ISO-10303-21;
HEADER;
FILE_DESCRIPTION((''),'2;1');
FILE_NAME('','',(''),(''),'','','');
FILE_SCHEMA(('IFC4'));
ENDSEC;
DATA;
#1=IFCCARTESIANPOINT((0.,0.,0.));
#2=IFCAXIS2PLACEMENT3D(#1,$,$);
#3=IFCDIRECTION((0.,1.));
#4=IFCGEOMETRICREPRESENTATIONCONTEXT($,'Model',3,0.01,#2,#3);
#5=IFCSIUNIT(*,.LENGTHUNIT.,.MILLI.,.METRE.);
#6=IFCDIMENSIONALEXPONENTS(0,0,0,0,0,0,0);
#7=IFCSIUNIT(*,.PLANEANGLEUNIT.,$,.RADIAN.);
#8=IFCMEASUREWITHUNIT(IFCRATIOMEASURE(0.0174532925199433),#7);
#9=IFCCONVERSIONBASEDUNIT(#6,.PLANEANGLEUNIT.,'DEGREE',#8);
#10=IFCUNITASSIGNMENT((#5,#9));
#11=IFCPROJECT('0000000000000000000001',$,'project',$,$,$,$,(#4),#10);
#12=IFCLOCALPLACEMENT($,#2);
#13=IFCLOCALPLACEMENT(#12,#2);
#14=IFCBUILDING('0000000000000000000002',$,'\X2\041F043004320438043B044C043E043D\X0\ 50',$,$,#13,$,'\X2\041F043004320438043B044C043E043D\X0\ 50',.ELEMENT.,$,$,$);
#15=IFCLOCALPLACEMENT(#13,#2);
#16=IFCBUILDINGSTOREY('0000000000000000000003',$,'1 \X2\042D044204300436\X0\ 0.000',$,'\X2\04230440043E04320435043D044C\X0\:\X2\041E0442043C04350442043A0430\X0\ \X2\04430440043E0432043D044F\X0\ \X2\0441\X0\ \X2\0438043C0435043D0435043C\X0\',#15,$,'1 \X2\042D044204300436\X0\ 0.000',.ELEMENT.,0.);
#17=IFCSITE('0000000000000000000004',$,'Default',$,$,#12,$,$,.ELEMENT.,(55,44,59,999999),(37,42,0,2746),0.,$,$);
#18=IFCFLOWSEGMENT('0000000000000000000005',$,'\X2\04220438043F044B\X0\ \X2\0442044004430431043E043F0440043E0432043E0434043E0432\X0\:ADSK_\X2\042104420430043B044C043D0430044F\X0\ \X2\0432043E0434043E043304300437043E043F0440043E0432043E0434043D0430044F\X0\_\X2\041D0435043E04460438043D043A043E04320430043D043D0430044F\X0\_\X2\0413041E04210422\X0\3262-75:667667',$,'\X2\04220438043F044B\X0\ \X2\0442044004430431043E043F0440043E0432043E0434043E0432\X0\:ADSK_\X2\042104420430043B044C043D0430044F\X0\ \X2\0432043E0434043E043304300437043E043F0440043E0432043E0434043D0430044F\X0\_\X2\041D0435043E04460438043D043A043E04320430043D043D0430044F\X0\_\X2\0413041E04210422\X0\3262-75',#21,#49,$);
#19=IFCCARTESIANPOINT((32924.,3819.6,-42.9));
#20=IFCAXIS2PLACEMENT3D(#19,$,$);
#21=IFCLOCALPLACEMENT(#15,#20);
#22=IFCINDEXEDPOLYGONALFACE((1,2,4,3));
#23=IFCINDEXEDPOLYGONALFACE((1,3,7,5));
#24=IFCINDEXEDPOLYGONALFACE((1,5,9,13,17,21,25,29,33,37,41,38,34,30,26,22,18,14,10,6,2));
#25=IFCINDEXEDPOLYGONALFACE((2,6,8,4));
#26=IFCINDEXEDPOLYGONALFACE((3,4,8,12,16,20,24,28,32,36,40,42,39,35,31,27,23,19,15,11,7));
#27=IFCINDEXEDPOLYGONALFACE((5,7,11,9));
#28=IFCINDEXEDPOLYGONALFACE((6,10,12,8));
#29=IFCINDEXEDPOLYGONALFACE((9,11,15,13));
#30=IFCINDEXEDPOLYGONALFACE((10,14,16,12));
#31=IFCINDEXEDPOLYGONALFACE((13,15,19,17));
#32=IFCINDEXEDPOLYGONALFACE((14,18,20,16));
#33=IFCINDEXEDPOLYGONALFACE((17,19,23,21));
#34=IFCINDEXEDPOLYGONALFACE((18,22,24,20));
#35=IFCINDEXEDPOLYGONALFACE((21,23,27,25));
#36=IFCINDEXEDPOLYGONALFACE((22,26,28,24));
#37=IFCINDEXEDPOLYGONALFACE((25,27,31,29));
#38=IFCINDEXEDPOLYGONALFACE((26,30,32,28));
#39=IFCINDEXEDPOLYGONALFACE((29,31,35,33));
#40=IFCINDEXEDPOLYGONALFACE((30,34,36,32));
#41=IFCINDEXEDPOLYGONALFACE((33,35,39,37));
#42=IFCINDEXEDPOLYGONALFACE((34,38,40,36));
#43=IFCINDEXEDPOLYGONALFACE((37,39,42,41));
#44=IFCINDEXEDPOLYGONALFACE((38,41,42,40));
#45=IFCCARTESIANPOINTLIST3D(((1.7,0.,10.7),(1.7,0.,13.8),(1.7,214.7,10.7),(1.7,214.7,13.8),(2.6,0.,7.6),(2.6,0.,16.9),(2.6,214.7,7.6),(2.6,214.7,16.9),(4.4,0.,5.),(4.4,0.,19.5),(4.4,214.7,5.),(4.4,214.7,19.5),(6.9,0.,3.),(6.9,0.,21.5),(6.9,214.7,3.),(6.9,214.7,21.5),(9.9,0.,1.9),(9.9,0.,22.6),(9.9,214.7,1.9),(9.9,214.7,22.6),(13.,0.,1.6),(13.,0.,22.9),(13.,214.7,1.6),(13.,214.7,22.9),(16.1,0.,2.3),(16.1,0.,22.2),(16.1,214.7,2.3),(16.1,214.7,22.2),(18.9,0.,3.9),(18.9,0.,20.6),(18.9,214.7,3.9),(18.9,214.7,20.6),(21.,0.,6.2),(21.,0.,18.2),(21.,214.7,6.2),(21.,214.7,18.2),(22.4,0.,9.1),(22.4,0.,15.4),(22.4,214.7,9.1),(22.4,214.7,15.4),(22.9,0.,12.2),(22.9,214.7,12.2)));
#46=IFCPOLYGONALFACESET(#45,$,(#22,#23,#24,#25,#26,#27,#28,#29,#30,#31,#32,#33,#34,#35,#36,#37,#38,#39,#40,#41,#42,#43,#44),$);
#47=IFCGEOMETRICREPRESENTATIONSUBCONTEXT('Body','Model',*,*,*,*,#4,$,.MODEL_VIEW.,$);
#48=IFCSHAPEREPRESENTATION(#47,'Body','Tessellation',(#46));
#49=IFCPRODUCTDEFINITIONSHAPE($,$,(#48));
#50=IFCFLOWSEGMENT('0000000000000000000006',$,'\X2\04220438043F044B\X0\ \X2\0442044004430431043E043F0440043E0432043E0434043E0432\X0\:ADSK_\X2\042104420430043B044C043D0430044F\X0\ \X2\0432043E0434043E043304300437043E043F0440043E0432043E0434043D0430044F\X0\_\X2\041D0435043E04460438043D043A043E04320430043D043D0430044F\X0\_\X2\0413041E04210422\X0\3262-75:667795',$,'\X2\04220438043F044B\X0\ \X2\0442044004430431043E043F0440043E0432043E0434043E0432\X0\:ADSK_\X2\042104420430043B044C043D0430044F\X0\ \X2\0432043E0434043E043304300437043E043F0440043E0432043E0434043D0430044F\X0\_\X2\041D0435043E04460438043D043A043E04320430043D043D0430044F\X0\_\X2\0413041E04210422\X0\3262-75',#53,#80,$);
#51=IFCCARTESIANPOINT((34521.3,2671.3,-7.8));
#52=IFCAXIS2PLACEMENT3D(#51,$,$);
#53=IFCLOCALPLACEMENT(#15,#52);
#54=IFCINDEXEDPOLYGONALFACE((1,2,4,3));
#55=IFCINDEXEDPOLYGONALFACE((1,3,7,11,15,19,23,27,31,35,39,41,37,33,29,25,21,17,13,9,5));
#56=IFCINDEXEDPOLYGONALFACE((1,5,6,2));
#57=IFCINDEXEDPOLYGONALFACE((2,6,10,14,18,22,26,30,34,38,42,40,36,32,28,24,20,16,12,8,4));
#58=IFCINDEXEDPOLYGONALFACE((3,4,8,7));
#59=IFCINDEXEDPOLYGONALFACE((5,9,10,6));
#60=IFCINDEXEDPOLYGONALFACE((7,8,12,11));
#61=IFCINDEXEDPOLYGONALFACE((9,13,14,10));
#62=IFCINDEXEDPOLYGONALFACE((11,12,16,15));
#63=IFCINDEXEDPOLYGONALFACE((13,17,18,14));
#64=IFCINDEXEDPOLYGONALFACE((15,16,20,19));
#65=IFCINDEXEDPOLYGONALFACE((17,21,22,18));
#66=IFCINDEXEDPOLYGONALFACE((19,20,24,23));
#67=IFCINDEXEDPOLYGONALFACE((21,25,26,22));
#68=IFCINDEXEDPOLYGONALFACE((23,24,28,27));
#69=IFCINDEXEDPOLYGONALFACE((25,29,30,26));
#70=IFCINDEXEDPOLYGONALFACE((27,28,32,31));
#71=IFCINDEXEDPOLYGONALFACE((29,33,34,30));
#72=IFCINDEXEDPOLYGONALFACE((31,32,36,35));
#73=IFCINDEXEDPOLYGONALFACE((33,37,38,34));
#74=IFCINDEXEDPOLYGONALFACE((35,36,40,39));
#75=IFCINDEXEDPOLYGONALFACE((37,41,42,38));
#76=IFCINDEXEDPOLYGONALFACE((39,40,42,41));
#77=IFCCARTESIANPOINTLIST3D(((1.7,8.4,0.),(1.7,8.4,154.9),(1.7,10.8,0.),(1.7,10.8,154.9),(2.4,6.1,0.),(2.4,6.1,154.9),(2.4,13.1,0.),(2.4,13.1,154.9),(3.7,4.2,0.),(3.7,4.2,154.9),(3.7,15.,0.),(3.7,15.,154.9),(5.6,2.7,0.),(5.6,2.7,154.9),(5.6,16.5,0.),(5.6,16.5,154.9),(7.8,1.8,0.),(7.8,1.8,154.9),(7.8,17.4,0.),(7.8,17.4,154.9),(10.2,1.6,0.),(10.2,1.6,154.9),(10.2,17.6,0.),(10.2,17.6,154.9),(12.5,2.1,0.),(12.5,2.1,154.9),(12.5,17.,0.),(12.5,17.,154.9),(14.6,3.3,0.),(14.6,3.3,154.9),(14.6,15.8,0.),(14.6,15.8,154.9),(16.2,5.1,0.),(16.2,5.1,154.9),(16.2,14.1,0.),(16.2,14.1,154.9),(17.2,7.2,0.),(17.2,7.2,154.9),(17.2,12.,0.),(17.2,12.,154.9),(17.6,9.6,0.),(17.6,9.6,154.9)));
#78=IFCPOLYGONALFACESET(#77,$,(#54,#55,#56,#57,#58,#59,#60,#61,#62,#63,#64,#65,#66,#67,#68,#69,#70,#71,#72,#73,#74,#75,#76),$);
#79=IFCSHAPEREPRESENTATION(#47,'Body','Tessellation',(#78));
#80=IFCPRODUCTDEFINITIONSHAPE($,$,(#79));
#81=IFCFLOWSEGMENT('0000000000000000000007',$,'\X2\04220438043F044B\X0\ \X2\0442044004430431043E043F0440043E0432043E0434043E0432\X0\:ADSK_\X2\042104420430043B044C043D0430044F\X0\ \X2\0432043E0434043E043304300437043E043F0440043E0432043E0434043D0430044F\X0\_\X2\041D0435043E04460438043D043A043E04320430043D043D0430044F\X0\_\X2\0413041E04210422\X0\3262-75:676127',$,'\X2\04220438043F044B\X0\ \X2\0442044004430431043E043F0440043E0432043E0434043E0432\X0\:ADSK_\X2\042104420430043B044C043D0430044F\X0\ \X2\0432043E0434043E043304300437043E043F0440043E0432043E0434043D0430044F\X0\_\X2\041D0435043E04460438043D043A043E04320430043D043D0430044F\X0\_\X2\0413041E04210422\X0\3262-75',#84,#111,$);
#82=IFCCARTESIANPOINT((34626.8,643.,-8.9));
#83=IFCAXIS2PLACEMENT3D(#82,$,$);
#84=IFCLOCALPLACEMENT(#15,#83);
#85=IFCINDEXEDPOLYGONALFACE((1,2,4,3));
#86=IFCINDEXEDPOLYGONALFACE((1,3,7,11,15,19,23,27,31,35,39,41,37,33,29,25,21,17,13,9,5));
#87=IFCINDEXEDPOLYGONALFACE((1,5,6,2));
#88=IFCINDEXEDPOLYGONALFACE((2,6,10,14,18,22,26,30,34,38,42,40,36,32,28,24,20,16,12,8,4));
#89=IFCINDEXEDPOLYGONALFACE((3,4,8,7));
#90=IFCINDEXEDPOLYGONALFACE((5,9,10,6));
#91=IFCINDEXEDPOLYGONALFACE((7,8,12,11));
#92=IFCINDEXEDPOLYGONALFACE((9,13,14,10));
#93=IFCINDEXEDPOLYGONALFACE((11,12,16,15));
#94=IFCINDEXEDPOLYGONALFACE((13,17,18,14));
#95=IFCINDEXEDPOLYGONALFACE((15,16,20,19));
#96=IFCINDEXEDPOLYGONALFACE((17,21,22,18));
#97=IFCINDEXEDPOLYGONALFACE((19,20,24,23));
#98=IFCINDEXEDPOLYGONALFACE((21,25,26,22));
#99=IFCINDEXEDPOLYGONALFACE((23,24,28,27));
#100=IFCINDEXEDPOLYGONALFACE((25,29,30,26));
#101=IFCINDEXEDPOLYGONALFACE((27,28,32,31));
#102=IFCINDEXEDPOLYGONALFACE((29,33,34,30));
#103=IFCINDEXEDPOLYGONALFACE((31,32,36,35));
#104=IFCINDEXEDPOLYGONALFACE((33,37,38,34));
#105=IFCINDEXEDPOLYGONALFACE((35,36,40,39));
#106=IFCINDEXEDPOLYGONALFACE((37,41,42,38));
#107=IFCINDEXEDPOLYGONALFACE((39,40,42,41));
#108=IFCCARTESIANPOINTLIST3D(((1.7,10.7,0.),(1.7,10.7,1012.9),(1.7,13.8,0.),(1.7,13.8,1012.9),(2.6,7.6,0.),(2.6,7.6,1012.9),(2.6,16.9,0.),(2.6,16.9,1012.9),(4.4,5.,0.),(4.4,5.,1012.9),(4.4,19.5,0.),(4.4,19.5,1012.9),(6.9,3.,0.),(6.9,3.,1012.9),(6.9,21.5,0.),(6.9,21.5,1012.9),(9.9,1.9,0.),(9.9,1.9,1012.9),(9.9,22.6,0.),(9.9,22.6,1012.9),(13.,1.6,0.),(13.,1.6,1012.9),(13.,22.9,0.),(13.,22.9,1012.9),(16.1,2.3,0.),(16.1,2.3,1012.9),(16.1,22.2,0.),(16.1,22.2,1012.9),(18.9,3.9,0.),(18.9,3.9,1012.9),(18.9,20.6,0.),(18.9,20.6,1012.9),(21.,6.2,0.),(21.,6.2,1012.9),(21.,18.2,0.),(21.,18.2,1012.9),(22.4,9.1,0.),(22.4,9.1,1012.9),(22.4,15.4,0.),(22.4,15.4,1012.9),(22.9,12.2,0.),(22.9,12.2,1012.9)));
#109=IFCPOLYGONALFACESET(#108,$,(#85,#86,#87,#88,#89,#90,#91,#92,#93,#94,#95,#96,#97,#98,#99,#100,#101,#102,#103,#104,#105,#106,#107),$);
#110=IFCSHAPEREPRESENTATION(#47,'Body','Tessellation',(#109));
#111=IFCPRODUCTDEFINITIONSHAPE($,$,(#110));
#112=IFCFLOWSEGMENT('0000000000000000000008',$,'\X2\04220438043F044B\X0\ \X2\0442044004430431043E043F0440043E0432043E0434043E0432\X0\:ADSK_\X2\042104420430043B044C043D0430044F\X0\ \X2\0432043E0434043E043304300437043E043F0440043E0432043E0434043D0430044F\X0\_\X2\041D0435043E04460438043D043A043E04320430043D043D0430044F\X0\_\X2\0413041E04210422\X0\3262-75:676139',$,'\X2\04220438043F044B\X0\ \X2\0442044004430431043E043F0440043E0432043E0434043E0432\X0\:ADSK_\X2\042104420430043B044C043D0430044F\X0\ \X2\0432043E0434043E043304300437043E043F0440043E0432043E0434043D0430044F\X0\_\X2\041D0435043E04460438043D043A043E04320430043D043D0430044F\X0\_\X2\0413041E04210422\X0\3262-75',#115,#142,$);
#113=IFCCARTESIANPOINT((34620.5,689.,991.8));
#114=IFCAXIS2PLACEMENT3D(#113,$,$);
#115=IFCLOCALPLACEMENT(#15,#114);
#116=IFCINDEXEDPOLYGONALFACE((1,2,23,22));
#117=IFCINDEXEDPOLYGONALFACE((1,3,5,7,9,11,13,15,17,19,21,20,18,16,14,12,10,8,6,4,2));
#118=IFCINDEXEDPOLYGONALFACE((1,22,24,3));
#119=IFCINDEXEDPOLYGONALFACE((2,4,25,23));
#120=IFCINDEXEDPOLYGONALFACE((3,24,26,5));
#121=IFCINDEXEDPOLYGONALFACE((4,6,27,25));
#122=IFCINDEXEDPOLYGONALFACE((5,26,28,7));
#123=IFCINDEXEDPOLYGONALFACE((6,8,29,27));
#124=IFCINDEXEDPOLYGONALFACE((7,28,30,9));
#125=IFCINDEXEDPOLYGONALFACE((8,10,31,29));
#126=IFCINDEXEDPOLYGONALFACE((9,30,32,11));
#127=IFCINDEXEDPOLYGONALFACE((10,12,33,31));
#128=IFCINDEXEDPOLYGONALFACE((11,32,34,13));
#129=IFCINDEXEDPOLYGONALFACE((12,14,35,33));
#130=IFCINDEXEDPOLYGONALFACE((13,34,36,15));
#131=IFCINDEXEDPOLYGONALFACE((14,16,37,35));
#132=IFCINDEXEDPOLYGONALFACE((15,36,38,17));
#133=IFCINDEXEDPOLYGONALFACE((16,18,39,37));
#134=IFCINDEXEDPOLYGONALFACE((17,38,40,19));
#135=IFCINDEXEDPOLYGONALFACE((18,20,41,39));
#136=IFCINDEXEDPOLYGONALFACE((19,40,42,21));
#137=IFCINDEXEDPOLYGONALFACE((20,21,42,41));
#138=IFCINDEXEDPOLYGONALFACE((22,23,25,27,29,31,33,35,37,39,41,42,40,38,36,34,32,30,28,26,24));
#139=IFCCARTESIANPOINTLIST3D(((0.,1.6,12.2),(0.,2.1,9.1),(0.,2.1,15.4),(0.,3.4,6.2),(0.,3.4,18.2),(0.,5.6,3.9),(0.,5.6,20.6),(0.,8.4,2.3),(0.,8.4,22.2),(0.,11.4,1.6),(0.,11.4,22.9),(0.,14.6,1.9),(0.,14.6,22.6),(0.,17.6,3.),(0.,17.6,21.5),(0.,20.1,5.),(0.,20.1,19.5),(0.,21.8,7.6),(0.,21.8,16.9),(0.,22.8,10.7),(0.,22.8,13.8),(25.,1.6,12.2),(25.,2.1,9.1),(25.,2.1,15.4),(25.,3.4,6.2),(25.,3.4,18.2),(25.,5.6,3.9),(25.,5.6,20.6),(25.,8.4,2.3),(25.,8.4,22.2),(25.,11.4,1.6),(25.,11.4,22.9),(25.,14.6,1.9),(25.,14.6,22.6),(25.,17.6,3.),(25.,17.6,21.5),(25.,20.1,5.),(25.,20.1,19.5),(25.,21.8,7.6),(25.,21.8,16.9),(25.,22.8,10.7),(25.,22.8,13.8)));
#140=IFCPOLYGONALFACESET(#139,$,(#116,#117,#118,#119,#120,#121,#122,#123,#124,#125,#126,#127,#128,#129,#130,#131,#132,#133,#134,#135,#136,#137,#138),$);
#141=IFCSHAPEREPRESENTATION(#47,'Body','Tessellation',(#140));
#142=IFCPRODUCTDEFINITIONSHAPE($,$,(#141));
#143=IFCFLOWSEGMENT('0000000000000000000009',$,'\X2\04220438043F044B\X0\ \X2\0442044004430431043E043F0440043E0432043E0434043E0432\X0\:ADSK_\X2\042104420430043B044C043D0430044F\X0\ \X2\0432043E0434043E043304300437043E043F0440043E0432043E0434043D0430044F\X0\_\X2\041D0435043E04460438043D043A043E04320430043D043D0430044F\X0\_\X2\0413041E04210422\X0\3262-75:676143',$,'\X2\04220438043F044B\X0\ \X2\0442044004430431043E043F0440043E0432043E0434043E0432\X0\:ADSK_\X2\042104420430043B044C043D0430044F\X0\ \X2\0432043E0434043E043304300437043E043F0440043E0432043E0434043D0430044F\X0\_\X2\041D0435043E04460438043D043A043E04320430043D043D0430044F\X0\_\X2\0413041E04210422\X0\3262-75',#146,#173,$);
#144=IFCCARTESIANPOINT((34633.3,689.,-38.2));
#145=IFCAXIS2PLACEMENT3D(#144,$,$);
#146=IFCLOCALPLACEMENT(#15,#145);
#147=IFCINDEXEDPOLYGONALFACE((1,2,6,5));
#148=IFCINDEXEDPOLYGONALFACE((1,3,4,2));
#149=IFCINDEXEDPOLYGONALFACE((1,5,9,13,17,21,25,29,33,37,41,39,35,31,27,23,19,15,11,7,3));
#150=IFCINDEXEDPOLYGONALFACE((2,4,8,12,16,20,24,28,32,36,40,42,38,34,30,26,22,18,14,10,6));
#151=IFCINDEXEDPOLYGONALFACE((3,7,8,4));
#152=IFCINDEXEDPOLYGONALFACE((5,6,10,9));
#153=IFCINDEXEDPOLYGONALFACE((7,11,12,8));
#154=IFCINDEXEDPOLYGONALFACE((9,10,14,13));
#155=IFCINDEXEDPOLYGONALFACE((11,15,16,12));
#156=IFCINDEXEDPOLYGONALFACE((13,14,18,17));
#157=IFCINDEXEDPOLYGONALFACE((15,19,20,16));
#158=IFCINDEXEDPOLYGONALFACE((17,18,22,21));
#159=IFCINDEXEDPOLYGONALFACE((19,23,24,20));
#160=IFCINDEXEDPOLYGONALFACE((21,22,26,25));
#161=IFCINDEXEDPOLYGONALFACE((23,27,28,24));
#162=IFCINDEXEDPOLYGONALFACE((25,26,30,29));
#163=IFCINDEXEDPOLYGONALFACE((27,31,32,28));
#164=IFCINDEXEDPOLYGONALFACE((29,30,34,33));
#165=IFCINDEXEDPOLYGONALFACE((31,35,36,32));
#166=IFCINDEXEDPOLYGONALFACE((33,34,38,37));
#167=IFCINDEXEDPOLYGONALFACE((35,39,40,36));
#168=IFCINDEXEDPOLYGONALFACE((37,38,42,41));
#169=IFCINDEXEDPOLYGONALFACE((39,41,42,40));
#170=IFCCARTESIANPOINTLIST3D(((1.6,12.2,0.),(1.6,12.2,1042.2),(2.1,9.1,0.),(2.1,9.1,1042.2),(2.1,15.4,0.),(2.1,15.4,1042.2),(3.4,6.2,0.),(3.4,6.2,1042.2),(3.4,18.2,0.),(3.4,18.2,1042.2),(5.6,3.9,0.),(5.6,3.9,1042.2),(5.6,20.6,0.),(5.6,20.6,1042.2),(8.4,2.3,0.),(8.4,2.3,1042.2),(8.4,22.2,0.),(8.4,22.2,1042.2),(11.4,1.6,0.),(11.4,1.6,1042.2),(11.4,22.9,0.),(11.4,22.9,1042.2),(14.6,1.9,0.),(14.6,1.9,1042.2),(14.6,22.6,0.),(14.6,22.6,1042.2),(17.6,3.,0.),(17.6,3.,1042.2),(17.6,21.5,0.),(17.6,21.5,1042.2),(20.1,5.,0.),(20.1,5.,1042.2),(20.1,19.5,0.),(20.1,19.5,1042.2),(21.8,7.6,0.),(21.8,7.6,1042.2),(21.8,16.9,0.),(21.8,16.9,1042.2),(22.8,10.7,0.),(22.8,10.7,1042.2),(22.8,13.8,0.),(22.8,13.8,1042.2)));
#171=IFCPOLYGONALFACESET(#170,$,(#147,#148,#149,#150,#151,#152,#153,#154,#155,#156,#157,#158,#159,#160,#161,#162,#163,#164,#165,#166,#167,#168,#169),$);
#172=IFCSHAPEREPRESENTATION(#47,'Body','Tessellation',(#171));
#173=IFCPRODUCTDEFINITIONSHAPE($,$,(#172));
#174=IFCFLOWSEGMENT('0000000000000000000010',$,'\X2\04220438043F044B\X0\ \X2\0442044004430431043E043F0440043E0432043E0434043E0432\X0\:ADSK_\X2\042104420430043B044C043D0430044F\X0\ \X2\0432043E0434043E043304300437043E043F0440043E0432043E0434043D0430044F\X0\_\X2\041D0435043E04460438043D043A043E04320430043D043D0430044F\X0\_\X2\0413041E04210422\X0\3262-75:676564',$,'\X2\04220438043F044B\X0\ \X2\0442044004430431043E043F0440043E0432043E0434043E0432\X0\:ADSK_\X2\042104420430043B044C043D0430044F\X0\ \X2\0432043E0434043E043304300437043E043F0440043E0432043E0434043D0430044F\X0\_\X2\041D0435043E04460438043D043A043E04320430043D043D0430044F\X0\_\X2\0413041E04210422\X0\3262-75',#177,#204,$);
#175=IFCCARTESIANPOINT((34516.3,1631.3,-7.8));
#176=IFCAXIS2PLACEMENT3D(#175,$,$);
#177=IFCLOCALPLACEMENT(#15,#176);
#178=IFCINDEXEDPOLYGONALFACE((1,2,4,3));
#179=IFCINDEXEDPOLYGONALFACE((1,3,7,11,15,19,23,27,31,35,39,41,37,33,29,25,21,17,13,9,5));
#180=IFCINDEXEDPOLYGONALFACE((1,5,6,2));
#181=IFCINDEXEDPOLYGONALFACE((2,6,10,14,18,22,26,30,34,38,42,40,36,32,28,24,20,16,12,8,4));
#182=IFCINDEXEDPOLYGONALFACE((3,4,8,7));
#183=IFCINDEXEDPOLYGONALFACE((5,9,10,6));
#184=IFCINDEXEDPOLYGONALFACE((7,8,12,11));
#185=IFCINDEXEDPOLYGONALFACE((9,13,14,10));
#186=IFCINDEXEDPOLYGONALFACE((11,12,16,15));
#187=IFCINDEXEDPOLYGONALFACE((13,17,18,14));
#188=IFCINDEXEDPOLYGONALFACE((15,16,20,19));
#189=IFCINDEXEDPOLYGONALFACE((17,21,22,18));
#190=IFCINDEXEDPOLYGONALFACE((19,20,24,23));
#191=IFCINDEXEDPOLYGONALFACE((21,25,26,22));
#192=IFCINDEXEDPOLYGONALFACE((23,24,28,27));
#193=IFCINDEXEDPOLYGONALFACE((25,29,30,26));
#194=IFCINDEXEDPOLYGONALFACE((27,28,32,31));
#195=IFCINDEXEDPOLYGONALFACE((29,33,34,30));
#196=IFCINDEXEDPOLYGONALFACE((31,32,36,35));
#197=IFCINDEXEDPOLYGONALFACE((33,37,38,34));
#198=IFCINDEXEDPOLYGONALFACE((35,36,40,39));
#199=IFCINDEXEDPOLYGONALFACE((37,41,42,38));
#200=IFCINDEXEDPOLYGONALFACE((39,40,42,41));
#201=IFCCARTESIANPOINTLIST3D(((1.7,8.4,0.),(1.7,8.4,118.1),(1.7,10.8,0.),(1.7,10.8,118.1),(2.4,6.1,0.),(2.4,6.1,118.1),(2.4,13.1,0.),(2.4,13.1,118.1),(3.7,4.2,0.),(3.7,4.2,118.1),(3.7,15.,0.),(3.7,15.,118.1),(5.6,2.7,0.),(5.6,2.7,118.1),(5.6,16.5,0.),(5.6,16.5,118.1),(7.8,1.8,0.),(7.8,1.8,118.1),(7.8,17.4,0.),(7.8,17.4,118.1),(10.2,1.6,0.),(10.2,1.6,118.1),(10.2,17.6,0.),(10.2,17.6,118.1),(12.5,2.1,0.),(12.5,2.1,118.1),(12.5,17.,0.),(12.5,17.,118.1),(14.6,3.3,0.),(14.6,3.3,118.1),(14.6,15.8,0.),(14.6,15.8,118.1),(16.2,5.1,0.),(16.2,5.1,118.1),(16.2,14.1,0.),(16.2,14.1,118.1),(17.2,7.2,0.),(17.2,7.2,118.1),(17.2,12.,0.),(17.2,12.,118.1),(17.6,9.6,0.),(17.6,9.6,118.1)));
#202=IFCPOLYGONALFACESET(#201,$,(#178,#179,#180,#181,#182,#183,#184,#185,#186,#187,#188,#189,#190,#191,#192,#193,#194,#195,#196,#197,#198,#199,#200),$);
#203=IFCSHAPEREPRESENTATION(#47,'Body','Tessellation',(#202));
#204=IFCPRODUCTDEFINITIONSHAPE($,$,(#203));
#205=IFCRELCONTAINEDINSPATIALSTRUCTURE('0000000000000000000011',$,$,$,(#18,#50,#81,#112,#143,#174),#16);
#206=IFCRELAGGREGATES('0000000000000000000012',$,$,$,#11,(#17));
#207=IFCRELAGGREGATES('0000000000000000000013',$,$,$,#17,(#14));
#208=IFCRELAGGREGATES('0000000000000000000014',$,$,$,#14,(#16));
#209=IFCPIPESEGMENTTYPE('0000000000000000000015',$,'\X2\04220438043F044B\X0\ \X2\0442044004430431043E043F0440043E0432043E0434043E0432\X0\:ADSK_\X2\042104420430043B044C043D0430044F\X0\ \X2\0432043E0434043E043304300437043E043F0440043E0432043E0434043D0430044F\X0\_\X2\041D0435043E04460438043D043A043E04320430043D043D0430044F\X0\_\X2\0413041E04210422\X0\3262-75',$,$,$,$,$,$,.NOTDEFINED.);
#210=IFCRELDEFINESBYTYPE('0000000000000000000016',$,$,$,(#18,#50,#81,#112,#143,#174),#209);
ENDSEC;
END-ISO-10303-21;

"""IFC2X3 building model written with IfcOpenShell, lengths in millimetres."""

from ifc_helpers import new_model, entity, si_unit, converted_unit, direction, frame, frame_2d, origin, origin_2d_with_axis, place, context, subcontext, project, spatial, circle, extrude, type_object, element, save


model = new_model("IFC2X3")

# Units and contexts
model_context = context("Model", 3, precision=0.01, world=origin(), true_north=direction((0.0, 1.0)))
body_context = subcontext(model_context, "Body", "Model", "MODEL_VIEW")
ifc_project = project(units=[si_unit("LENGTHUNIT", "METRE", prefix="MILLI"), converted_unit("PLANEANGLEUNIT", "DEGREE", entity("IfcRatioMeasure", 0.0174532925199433), si_unit("PLANEANGLEUNIT", "RADIAN"), dimensions=[0, 0, 0, 0, 0, 0, 0])], contexts=[model_context])

# Site, building, storey
site_placement = place(None, origin())
site = spatial("IfcSite", under=ifc_project, at=site_placement, Name="Default", CompositionType="ELEMENT", RefLatitude=(55, 44, 59, 999999), RefLongitude=(37, 42, 0, 2746), RefElevation=0.0)
building_placement = place(site_placement, origin())
building = spatial("IfcBuilding", under=site, at=building_placement, Name="Павильон 50", LongName="Павильон 50", CompositionType="ELEMENT")
storey_placement = place(building_placement, origin())
storey = spatial("IfcBuildingStorey", under=building, at=storey_placement, Name="1 Этаж 0.000", ObjectType="Уровень:Отметка уровня с именем", LongName="1 Этаж 0.000", CompositionType="ELEMENT", Elevation=0.0)

# Flow segments
pipe_segment_type = type_object("IfcPipeSegmentType", Name="Типы трубопроводов:ADSK_Стальная водогазопроводная_Неоцинкованная_ГОСТ3262-75", PredefinedType="NOTDEFINED")
flow_segment_1_placement = place(storey_placement, frame((32924.0, 3819.6, -42.9)))
element("IfcFlowSegment", 1, at=flow_segment_1_placement, inside=storey, type_object=pipe_segment_type, Name="Типы трубопроводов:ADSK_Стальная водогазопроводная_Неоцинкованная_ГОСТ3262-75:667667", ObjectType="Типы трубопроводов:ADSK_Стальная водогазопроводная_Неоцинкованная_ГОСТ3262-75", context=body_context, shape_type="SweptSolid", body=[
    extrude(circle(Radius=10.7, at=frame_2d((0.0, 0.0), x_axis=(1.0, 0.0))), frame((12.2, 0.0, 12.2), z_axis=(0.0, 1.0, 0.0), x_axis=(1.0, 0.0, 0.0)), (0.0, 0.0, 1.0), 214.7),
])
flow_segment_2_placement = place(storey_placement, frame((34521.3, 2671.3, -7.8)))
element("IfcFlowSegment", 2, at=flow_segment_2_placement, inside=storey, type_object=pipe_segment_type, Name="Типы трубопроводов:ADSK_Стальная водогазопроводная_Неоцинкованная_ГОСТ3262-75:667795", ObjectType="Типы трубопроводов:ADSK_Стальная водогазопроводная_Неоцинкованная_ГОСТ3262-75", context=body_context, shape_type="SweptSolid", body=[
    extrude(circle(Radius=8.0, at=frame_2d((0.0, 0.0), x_axis=(1.0, 0.0))), frame((9.6, 9.6, 0.0)), (0.0, 0.0, 1.0), 154.9),
])
flow_segment_3_placement = place(storey_placement, frame((34626.8, 643.0, -8.9)))
element("IfcFlowSegment", 3, at=flow_segment_3_placement, inside=storey, type_object=pipe_segment_type, Name="Типы трубопроводов:ADSK_Стальная водогазопроводная_Неоцинкованная_ГОСТ3262-75:676127", ObjectType="Типы трубопроводов:ADSK_Стальная водогазопроводная_Неоцинкованная_ГОСТ3262-75", context=body_context, shape_type="SweptSolid", body=[
    extrude(circle(Radius=10.7, at=origin_2d_with_axis()), frame((12.2, 12.2, 0.0)), (0.0, 0.0, 1.0), 1012.9),
])
flow_segment_4_placement = place(storey_placement, frame((34620.5, 689.0, 991.8)))
element("IfcFlowSegment", 4, at=flow_segment_4_placement, inside=storey, type_object=pipe_segment_type, Name="Типы трубопроводов:ADSK_Стальная водогазопроводная_Неоцинкованная_ГОСТ3262-75:676139", ObjectType="Типы трубопроводов:ADSK_Стальная водогазопроводная_Неоцинкованная_ГОСТ3262-75", context=body_context, shape_type="SweptSolid", body=[
    extrude(circle(Radius=10.7, at=origin_2d_with_axis()), frame((0.0, 12.2, 12.2), z_axis=(1.0, 0.0, 0.0), x_axis=(0.0, -1.0, 0.0)), (0.0, 0.0, 1.0), 25.0),
])
flow_segment_5_placement = place(storey_placement, frame((34633.3, 689.0, -38.2)))
element("IfcFlowSegment", 5, at=flow_segment_5_placement, inside=storey, type_object=pipe_segment_type, Name="Типы трубопроводов:ADSK_Стальная водогазопроводная_Неоцинкованная_ГОСТ3262-75:676143", ObjectType="Типы трубопроводов:ADSK_Стальная водогазопроводная_Неоцинкованная_ГОСТ3262-75", context=body_context, shape_type="SweptSolid", body=[
    extrude(circle(Radius=10.7, at=origin_2d_with_axis()), frame((12.2, 12.2, 0.0), z_axis=(0.0, 0.0, 1.0), x_axis=(-1.0, 0.0, 0.0)), (0.0, 0.0, 1.0), 1042.2),
])
flow_segment_6_placement = place(storey_placement, frame((34516.3, 1631.3, -7.8)))
element("IfcFlowSegment", 6, at=flow_segment_6_placement, inside=storey, type_object=pipe_segment_type, Name="Типы трубопроводов:ADSK_Стальная водогазопроводная_Неоцинкованная_ГОСТ3262-75:676564", ObjectType="Типы трубопроводов:ADSK_Стальная водогазопроводная_Неоцинкованная_ГОСТ3262-75", context=body_context, shape_type="SweptSolid", body=[
    extrude(circle(Radius=8.0, at=frame_2d((0.0, 0.0), x_axis=(1.0, 0.0))), frame((9.6, 9.6, 0.0)), (0.0, 0.0, 1.0), 118.1),
])

save(model, "model.ifc")
